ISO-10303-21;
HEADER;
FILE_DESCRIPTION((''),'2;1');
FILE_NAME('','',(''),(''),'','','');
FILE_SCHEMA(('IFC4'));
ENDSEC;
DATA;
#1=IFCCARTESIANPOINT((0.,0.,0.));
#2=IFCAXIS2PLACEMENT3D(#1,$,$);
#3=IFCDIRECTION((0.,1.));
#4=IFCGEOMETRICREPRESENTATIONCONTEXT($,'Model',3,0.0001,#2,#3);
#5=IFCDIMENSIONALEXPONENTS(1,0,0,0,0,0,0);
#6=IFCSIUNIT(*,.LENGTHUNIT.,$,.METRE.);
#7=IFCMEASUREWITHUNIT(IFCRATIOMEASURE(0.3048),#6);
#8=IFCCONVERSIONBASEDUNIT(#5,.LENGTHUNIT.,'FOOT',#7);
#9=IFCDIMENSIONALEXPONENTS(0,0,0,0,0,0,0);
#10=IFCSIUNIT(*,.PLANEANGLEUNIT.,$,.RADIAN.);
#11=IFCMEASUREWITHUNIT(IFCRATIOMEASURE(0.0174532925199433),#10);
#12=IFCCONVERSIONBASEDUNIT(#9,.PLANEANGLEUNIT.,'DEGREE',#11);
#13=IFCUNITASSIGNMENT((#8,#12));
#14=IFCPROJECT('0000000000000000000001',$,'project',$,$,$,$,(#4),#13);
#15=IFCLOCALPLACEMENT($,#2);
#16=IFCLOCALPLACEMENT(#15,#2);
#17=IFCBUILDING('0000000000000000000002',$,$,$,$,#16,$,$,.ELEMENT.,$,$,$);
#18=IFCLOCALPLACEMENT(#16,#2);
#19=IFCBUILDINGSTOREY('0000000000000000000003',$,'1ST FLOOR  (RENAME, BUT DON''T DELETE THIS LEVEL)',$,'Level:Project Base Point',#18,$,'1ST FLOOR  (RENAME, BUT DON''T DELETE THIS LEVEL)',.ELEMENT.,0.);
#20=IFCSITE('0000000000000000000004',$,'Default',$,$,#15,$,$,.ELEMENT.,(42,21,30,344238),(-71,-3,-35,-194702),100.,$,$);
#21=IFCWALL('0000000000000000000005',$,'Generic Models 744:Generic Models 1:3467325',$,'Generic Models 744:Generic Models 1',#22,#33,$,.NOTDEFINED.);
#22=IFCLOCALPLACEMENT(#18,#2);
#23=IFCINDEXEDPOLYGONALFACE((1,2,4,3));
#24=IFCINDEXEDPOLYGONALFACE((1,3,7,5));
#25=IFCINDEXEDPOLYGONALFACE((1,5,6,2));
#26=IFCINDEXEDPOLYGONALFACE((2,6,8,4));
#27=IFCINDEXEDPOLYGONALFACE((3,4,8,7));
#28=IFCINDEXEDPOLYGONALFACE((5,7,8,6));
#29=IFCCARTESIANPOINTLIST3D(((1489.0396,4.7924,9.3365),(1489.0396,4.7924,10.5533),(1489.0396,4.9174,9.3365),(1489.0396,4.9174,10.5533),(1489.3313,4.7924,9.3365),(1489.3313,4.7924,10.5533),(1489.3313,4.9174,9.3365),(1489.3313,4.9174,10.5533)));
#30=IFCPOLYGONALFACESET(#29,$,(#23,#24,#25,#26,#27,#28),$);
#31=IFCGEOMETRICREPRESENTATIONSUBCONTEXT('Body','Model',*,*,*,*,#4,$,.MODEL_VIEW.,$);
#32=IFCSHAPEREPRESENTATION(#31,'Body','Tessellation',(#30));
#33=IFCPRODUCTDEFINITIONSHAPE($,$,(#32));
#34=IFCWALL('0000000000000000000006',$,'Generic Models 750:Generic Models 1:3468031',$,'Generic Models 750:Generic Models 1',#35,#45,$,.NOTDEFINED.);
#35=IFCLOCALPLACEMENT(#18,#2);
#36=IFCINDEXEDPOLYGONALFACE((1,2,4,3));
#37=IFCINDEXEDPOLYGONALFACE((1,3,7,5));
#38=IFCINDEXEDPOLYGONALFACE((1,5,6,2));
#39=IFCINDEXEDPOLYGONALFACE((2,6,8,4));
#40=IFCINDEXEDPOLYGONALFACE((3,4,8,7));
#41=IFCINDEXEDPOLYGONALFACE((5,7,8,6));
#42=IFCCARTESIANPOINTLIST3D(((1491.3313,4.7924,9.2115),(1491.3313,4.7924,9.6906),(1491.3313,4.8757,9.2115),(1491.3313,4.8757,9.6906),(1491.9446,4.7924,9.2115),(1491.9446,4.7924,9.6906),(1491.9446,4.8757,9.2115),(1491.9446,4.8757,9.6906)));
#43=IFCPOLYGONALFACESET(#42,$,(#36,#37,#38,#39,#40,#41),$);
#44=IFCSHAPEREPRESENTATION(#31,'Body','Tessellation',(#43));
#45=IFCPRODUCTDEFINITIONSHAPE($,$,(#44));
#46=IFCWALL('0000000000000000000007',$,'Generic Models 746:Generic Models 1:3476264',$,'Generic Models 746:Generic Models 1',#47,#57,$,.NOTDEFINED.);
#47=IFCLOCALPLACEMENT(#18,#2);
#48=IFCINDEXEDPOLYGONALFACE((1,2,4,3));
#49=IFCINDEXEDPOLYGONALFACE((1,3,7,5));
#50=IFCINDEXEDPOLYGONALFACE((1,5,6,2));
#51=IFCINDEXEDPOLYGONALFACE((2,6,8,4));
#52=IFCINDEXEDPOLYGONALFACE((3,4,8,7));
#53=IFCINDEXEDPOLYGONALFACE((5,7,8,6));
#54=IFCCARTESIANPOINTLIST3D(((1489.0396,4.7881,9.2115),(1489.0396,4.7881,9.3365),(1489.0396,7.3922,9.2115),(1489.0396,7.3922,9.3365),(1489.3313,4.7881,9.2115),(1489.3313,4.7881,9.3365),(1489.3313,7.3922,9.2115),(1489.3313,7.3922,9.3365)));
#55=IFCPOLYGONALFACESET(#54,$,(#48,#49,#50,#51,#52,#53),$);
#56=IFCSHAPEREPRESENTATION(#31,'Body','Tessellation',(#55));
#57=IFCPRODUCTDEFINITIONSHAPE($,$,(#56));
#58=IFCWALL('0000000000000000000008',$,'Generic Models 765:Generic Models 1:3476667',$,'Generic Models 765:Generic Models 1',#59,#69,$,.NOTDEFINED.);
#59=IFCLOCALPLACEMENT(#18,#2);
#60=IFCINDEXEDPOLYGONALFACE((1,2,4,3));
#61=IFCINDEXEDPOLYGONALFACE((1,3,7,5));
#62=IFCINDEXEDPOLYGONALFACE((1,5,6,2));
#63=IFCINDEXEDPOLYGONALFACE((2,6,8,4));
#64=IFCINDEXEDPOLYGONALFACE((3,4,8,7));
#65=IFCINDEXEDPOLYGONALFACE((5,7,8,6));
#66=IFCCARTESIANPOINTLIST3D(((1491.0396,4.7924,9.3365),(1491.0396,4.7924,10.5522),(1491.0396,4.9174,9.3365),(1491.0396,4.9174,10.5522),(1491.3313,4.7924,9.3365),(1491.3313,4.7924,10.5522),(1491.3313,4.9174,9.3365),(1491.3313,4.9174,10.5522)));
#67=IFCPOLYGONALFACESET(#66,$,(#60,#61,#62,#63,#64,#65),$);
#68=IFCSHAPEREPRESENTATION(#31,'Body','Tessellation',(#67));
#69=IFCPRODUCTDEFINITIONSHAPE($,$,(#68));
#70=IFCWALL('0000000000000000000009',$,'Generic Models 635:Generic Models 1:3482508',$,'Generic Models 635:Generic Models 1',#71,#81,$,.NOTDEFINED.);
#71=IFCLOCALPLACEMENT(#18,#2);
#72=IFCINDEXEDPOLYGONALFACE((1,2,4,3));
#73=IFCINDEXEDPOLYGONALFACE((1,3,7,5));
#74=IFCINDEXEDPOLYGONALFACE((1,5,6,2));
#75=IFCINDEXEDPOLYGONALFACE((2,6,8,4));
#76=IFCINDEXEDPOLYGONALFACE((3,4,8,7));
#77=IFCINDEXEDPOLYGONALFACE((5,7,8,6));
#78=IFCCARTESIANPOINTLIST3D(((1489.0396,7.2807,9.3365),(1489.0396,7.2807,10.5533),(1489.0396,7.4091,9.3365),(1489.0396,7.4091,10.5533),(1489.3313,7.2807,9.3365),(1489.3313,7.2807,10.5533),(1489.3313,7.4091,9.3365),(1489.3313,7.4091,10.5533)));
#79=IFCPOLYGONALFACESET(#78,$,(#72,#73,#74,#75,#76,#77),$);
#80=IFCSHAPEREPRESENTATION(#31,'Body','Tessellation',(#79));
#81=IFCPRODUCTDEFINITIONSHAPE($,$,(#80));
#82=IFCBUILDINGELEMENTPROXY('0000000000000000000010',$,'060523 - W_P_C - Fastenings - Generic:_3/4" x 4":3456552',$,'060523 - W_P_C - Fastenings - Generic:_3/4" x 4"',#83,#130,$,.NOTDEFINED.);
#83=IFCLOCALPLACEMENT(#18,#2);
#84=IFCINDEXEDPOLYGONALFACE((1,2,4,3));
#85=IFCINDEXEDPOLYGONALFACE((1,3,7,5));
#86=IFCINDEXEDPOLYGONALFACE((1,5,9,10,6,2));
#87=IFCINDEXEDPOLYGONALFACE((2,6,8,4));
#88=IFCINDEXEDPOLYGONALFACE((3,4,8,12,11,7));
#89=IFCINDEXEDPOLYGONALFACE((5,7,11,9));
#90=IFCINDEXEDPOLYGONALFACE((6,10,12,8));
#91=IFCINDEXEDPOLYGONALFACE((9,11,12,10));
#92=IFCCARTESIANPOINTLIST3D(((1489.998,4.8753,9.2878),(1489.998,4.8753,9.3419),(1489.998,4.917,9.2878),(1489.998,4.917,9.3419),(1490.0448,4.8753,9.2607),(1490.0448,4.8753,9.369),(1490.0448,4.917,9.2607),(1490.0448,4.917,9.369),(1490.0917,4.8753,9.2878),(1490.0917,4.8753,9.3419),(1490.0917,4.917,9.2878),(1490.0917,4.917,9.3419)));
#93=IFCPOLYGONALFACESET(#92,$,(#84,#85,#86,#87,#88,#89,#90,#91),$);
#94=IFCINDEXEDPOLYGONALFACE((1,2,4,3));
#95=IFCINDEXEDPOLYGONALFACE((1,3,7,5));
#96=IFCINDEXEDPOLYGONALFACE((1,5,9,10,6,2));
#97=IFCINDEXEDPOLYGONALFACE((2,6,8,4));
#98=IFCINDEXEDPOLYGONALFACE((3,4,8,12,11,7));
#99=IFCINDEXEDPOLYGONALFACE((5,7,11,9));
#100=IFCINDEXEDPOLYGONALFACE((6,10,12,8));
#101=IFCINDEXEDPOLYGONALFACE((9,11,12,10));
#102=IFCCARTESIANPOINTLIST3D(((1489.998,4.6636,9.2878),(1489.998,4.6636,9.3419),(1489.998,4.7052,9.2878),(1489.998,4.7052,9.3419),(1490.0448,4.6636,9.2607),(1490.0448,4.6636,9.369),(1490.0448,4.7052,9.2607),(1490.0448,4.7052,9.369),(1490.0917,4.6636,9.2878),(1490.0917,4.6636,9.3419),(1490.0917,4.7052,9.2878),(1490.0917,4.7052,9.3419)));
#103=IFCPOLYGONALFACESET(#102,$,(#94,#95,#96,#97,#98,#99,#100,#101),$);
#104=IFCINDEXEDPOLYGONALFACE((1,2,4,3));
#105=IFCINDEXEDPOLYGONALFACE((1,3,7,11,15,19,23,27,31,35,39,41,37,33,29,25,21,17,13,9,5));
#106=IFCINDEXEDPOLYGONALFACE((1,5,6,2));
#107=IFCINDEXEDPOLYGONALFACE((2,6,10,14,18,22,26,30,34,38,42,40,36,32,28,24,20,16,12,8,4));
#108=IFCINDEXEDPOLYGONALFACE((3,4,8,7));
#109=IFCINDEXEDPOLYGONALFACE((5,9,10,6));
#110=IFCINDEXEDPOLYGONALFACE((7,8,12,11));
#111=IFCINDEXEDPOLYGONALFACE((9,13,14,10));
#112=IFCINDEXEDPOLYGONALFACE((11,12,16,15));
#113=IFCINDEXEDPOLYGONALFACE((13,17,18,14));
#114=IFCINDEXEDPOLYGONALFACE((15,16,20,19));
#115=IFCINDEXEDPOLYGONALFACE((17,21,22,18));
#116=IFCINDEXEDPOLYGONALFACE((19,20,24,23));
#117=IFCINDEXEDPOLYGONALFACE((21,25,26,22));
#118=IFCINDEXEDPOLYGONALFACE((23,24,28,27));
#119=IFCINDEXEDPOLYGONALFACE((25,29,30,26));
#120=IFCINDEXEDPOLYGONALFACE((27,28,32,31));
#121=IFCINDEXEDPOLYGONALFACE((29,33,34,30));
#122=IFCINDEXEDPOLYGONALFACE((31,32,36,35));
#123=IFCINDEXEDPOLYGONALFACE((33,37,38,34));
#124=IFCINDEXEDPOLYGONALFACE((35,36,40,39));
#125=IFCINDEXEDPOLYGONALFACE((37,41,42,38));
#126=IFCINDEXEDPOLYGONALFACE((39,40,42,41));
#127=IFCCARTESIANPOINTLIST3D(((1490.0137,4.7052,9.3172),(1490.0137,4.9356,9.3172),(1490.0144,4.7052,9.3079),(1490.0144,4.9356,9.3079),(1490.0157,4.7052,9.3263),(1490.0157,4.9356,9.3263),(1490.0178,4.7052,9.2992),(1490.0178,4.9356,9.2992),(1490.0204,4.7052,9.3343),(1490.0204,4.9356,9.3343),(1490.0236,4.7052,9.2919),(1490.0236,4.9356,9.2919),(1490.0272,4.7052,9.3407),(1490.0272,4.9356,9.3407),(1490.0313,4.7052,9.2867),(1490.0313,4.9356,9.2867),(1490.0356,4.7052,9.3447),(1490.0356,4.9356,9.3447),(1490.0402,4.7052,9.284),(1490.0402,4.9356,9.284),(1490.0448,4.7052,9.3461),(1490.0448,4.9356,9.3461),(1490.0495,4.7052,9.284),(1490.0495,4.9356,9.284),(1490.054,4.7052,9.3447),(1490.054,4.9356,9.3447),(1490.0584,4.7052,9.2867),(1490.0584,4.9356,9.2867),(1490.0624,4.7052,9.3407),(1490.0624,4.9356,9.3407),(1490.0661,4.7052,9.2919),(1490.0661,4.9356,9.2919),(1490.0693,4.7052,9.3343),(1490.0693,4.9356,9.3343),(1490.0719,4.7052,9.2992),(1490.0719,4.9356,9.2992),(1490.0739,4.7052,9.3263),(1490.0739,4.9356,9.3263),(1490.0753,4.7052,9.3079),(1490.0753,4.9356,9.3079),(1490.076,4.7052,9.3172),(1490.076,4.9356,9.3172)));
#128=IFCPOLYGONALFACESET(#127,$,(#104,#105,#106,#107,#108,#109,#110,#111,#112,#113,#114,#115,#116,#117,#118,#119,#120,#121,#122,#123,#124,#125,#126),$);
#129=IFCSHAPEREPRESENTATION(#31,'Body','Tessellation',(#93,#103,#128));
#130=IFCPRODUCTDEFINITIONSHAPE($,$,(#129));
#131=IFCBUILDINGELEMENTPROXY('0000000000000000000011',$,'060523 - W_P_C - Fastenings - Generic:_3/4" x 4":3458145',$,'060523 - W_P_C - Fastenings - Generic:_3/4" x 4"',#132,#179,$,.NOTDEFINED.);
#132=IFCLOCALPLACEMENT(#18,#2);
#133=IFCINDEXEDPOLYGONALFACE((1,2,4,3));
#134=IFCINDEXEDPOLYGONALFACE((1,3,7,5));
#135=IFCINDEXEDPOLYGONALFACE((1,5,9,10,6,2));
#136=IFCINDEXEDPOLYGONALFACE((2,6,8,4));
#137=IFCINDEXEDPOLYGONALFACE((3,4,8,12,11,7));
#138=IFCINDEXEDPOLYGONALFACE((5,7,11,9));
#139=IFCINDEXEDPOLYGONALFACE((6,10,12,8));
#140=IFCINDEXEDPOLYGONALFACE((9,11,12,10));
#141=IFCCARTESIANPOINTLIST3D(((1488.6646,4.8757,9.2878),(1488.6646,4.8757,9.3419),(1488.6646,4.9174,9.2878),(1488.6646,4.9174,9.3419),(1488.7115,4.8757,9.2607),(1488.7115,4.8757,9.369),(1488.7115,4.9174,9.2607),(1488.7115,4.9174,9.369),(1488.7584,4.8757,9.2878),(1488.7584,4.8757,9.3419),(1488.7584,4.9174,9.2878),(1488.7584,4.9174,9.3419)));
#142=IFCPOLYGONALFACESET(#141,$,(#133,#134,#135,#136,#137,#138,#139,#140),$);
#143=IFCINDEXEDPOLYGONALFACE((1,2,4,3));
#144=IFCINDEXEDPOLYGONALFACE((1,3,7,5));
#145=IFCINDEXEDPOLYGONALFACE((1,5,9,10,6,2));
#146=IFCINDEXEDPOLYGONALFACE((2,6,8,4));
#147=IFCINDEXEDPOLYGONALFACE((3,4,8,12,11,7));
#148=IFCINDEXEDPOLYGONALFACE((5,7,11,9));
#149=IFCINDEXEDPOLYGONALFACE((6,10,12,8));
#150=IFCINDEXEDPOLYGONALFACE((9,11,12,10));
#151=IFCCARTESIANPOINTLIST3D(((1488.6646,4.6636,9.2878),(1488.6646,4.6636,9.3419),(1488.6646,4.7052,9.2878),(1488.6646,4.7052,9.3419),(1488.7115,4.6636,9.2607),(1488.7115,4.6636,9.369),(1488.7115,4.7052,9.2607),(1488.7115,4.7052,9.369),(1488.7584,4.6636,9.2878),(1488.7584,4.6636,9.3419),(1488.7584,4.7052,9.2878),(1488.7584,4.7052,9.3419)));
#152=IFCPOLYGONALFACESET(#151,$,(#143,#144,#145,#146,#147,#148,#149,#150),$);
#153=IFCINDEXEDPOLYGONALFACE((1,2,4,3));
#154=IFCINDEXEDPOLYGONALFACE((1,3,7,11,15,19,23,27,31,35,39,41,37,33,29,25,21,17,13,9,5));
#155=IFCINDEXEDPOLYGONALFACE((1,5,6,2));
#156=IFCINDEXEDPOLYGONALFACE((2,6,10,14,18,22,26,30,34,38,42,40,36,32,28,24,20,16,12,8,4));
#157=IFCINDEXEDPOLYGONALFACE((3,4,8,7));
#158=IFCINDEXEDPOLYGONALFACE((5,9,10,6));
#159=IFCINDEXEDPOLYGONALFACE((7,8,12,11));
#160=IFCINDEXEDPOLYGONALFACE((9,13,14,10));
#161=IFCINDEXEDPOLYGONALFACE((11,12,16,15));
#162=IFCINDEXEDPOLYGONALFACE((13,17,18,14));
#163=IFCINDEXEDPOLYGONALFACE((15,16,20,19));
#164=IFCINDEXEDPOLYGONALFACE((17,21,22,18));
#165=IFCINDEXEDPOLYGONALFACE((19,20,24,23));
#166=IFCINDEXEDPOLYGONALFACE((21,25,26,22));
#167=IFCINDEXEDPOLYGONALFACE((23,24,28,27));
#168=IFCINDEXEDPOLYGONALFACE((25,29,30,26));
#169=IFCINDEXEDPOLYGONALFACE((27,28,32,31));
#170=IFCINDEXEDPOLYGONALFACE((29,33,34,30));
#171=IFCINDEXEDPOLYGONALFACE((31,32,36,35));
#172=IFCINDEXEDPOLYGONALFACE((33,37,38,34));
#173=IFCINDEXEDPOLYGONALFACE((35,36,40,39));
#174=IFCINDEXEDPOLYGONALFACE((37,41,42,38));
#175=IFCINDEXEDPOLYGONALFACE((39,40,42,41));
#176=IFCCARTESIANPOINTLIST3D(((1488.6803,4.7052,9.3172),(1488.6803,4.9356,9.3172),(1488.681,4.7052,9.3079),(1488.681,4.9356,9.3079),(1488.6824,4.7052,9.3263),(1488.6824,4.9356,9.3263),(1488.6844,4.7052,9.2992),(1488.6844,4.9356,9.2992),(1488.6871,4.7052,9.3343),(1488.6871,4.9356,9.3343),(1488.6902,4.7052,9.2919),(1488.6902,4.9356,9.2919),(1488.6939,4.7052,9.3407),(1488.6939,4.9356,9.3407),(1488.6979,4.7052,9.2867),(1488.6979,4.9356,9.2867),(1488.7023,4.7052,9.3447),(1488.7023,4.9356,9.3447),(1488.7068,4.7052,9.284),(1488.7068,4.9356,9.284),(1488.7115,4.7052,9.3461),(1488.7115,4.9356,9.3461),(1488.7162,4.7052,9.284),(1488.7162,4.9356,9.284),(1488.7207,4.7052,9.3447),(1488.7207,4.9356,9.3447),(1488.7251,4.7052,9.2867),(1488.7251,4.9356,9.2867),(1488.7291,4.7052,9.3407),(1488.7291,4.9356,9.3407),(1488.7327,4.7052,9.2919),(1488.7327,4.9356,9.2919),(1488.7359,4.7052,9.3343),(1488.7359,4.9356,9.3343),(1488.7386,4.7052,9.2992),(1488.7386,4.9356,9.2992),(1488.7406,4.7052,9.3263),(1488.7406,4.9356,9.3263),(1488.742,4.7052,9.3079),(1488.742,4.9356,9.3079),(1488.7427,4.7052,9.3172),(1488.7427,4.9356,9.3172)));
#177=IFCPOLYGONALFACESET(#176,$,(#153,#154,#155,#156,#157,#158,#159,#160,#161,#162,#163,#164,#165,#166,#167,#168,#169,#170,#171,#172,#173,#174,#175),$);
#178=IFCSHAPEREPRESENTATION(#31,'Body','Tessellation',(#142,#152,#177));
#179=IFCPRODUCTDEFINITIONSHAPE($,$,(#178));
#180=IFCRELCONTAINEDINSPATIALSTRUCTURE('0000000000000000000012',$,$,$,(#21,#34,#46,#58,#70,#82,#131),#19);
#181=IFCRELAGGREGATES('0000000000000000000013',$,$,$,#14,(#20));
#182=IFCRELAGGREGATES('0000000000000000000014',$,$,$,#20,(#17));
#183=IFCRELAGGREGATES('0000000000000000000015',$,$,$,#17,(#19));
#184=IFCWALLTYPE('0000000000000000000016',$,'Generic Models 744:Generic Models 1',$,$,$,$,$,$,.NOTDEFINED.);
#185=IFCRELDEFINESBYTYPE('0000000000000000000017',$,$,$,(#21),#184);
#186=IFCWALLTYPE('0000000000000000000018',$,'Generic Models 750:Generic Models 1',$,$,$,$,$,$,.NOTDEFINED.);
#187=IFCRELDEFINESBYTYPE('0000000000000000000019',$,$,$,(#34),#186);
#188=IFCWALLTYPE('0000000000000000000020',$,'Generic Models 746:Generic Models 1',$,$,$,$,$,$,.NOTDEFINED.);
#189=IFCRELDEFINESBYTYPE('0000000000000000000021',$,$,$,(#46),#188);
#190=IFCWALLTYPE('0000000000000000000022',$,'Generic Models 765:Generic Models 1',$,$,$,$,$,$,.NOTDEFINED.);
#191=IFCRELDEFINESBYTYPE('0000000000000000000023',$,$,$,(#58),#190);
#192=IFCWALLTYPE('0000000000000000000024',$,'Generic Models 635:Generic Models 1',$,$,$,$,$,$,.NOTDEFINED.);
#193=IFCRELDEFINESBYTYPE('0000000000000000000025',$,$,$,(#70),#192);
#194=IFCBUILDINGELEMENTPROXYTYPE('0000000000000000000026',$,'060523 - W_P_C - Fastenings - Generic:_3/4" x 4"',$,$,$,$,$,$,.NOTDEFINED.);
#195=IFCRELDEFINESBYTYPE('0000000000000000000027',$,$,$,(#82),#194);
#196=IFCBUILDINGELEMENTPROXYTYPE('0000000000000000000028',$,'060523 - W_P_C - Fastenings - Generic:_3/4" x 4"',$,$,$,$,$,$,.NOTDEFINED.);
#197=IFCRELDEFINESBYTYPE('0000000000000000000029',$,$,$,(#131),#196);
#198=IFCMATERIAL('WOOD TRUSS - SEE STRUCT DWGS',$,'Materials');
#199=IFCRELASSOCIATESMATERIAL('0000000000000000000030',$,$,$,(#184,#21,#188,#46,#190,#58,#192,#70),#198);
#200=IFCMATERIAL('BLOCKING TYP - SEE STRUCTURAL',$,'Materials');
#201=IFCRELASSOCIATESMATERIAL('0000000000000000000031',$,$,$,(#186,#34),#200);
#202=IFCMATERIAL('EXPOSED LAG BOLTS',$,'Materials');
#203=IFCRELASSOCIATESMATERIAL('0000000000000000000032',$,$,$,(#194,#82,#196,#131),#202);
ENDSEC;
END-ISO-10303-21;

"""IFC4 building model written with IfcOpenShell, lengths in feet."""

from ifc_helpers import new_model, entity, si_unit, converted_unit, direction, frame, frame_2d, origin, place, context, subcontext, project, spatial, polyline, rectangle, circle, outline, extrude, source, transform, mapped, material, type_object, type_shapes, element, save


model = new_model("IFC4")

# Units and contexts
model_context = context("Model", 3, precision=0.0001, world=origin(), true_north=direction((0.0, 1.0)))
body_context = subcontext(model_context, "Body", "Model", "MODEL_VIEW")
ifc_project = project(units=[converted_unit("LENGTHUNIT", "FOOT", entity("IfcRatioMeasure", 0.3048), si_unit("LENGTHUNIT", "METRE"), dimensions=[1, 0, 0, 0, 0, 0, 0]), converted_unit("PLANEANGLEUNIT", "DEGREE", entity("IfcRatioMeasure", 0.0174532925199433), si_unit("PLANEANGLEUNIT", "RADIAN"), dimensions=[0, 0, 0, 0, 0, 0, 0])], contexts=[model_context])

# Site, building, storey
site_placement = place(None, origin())
site = spatial("IfcSite", under=ifc_project, at=site_placement, Name="Default", CompositionType="ELEMENT", RefLatitude=(42, 21, 30, 344238), RefLongitude=(-71, -3, -35, -194702), RefElevation=100.0)
building_placement = place(site_placement, origin())
building = spatial("IfcBuilding", under=site, at=building_placement, CompositionType="ELEMENT")
storey_placement = place(building_placement, origin())
storey = spatial("IfcBuildingStorey", under=building, at=storey_placement, Name="1ST FLOOR  (RENAME, BUT DON'T DELETE THIS LEVEL)", ObjectType="Level:Project Base Point", LongName="1ST FLOOR  (RENAME, BUT DON'T DELETE THIS LEVEL)", CompositionType="ELEMENT", Elevation=0.0)

# Walls
ifc_material_1 = material(Name="WOOD TRUSS - SEE STRUCT DWGS", Category="Materials")
ifc_material_2 = material(Name="BLOCKING TYP - SEE STRUCTURAL", Category="Materials")
wall_type_1 = type_object("IfcWallType", Name="Generic Models 744:Generic Models 1", PredefinedType="NOTDEFINED", material=ifc_material_1)
wall_1_placement = place(storey_placement, frame((1489.0396, 4.7924, 9.3365)))
element("IfcWall", 1, at=wall_1_placement, inside=storey, type_object=wall_type_1, material=ifc_material_1, Name="Generic Models 744:Generic Models 1:3467325", ObjectType="Generic Models 744:Generic Models 1", PredefinedType="NOTDEFINED", context=body_context, shape_type="SweptSolid", body=[
    extrude(rectangle(XDim=0.125, YDim=0.2917, at=frame_2d((0.0, 0.0), x_axis=(1.0, 0.0))), frame((0.1458, 0.0625, 0.0), z_axis=(0.0, 0.0, 1.0), x_axis=(0.0, 1.0, 0.0)), (0.0, 0.0, 1.0), 1.2168),
])
wall_type_2 = type_object("IfcWallType", Name="Generic Models 750:Generic Models 1", PredefinedType="NOTDEFINED", material=ifc_material_2)
wall_2_placement = place(storey_placement, frame((1491.3313, 4.7924, 9.2115)))
element("IfcWall", 2, at=wall_2_placement, inside=storey, type_object=wall_type_2, material=ifc_material_2, Name="Generic Models 750:Generic Models 1:3468031", ObjectType="Generic Models 750:Generic Models 1", PredefinedType="NOTDEFINED", context=body_context, shape_type="SweptSolid", body=[
    extrude(rectangle(XDim=0.0833, YDim=0.6133, at=frame_2d((0.0, 0.0), x_axis=(1.0, 0.0))), frame((0.3066, 0.0417, 0.0), z_axis=(0.0, 0.0, 1.0), x_axis=(0.0, 1.0, 0.0)), (0.0, 0.0, 1.0), 0.4792),
])
wall_type_3 = type_object("IfcWallType", Name="Generic Models 746:Generic Models 1", PredefinedType="NOTDEFINED", material=ifc_material_1)
wall_3_placement = place(storey_placement, frame((1489.0396, 4.7881, 9.2115), z_axis=(0.0, 0.0, 1.0), x_axis=(0.0, 1.0, 0.0)))
element("IfcWall", 3, at=wall_3_placement, inside=storey, type_object=wall_type_3, material=ifc_material_1, Name="Generic Models 746:Generic Models 1:3476264", ObjectType="Generic Models 746:Generic Models 1", PredefinedType="NOTDEFINED", context=body_context, shape_type="SweptSolid", body=[
    extrude(rectangle(XDim=2.6042, YDim=0.2917, at=frame_2d((0.0, 0.0), x_axis=(1.0, 0.0))), frame((1.3021, -0.1458, 0.0)), (0.0, 0.0, 1.0), 0.125),
])
wall_type_4 = type_object("IfcWallType", Name="Generic Models 765:Generic Models 1", PredefinedType="NOTDEFINED", material=ifc_material_1)
wall_4_placement = place(storey_placement, frame((1491.0396, 4.7924, 9.3365)))
element("IfcWall", 4, at=wall_4_placement, inside=storey, type_object=wall_type_4, material=ifc_material_1, Name="Generic Models 765:Generic Models 1:3476667", ObjectType="Generic Models 765:Generic Models 1", PredefinedType="NOTDEFINED", context=body_context, shape_type="SweptSolid", body=[
    extrude(rectangle(XDim=0.125, YDim=0.2917, at=frame_2d((0.0, 0.0), x_axis=(1.0, 0.0))), frame((0.1458, 0.0625, 0.0), z_axis=(0.0, 0.0, 1.0), x_axis=(0.0, 1.0, 0.0)), (0.0, 0.0, 1.0), 1.2157),
])
wall_type_5 = type_object("IfcWallType", Name="Generic Models 635:Generic Models 1", PredefinedType="NOTDEFINED", material=ifc_material_1)
wall_5_placement = place(storey_placement, frame((1489.0396, 7.2807, 9.3365)))
element("IfcWall", 5, at=wall_5_placement, inside=storey, type_object=wall_type_5, material=ifc_material_1, Name="Generic Models 635:Generic Models 1:3482508", ObjectType="Generic Models 635:Generic Models 1", PredefinedType="NOTDEFINED", context=body_context, shape_type="SweptSolid", body=[
    extrude(rectangle(XDim=0.1283, YDim=0.2917, at=frame_2d((0.0, 0.0), x_axis=(1.0, 0.0))), frame((0.1458, 0.0642, 0.0), z_axis=(0.0, 0.0, 1.0), x_axis=(0.0, 1.0, 0.0)), (0.0, 0.0, 1.0), 1.2168),
])

# Building element proxies
ifc_material_3 = material(Name="EXPOSED LAG BOLTS", Category="Materials")
building_element_proxy_type_1 = type_object("IfcBuildingElementProxyType", Name="060523 - W_P_C - Fastenings - Generic:_3/4\" x 4\"", PredefinedType="NOTDEFINED", material=ifc_material_3)
shared_shape_1 = source(origin(), body_context, "Body", "SweptSolid", [
    extrude(outline(polyline([(-0.0271, -0.0469), (0.0271, -0.0469), (0.0541, 0.0), (0.0271, 0.0469), (-0.0271, 0.0469), (-0.0541, 0.0), (-0.0271, -0.0469)])), frame((0.0, 0.0, -0.2118), z_axis=(0.0, 0.0, 1.0), x_axis=(0.866025, -0.5, 0.0)), (0.0, 0.0, 1.0), 0.0417),
    extrude(outline(polyline([(-0.0271, -0.0469), (0.0271, -0.0469), (0.0541, 0.0), (0.0271, 0.0469), (-0.0271, 0.0469), (-0.0541, 0.0), (-0.0271, -0.0469)])), frame((0.0, 0.0, 0.0), z_axis=(0.0, 0.0, 1.0), x_axis=(0.0, -1.0, 0.0)), (0.0, 0.0, 1.0), 0.0417),
    extrude(circle(Radius=0.0312, at=frame_2d((0.0, 0.0), x_axis=(1.0, 0.0))), frame((0.0, 0.0, -0.2304), z_axis=(0.0, 0.0, 1.0), x_axis=(0.0, 1.0, 0.0)), (0.0, 0.0, 1.0), 0.2304),
])
type_shapes(building_element_proxy_type_1, [shared_shape_1])
proxy_1_placement = place(storey_placement, frame((1490.0448, 4.7052, 9.3149), z_axis=(0.0, -1.0, 0.0), x_axis=(1.0, 0.0, 0.0)))
element("IfcBuildingElementProxy", 6, at=proxy_1_placement, inside=storey, type_object=building_element_proxy_type_1, material=ifc_material_3, Name="060523 - W_P_C - Fastenings - Generic:_3/4\" x 4\":3456552", ObjectType="060523 - W_P_C - Fastenings - Generic:_3/4\" x 4\"", PredefinedType="NOTDEFINED", context=body_context, shape_type="MappedRepresentation", body=[
    mapped(shared_shape_1, transform((0.0, 0.0, 0.0), scale=1.0)),
])
building_element_proxy_type_2 = type_object("IfcBuildingElementProxyType", Name="060523 - W_P_C - Fastenings - Generic:_3/4\" x 4\"", PredefinedType="NOTDEFINED", material=ifc_material_3)
shared_shape_2 = source(origin(), body_context, "Body", "SweptSolid", [
    extrude(outline(polyline([(-0.0271, -0.0469), (0.0271, -0.0469), (0.0541, 0.0), (0.0271, 0.0469), (-0.0271, 0.0469), (-0.0541, 0.0), (-0.0271, -0.0469)])), frame((0.0, 0.0, -0.2121), z_axis=(0.0, 0.0, 1.0), x_axis=(0.866025, -0.5, 0.0)), (0.0, 0.0, 1.0), 0.0417),
    extrude(outline(polyline([(-0.0271, -0.0469), (0.0271, -0.0469), (0.0541, 0.0), (0.0271, 0.0469), (-0.0271, 0.0469), (-0.0541, 0.0), (-0.0271, -0.0469)])), frame((0.0, 0.0, 0.0), z_axis=(0.0, 0.0, 1.0), x_axis=(0.0, -1.0, 0.0)), (0.0, 0.0, 1.0), 0.0417),
    extrude(circle(Radius=0.0312, at=frame_2d((0.0, 0.0), x_axis=(1.0, 0.0))), frame((0.0, 0.0, -0.2304), z_axis=(0.0, 0.0, 1.0), x_axis=(0.0, 1.0, 0.0)), (0.0, 0.0, 1.0), 0.2304),
])
type_shapes(building_element_proxy_type_2, [shared_shape_2])
proxy_2_placement = place(storey_placement, frame((1488.7115, 4.7052, 9.3149), z_axis=(0.0, -1.0, 0.0), x_axis=(1.0, 0.0, 0.0)))
element("IfcBuildingElementProxy", 7, at=proxy_2_placement, inside=storey, type_object=building_element_proxy_type_2, material=ifc_material_3, Name="060523 - W_P_C - Fastenings - Generic:_3/4\" x 4\":3458145", ObjectType="060523 - W_P_C - Fastenings - Generic:_3/4\" x 4\"", PredefinedType="NOTDEFINED", context=body_context, shape_type="MappedRepresentation", body=[
    mapped(shared_shape_2, transform((0.0, 0.0, 0.0), scale=1.0)),
])

save(model, "model.ifc")
